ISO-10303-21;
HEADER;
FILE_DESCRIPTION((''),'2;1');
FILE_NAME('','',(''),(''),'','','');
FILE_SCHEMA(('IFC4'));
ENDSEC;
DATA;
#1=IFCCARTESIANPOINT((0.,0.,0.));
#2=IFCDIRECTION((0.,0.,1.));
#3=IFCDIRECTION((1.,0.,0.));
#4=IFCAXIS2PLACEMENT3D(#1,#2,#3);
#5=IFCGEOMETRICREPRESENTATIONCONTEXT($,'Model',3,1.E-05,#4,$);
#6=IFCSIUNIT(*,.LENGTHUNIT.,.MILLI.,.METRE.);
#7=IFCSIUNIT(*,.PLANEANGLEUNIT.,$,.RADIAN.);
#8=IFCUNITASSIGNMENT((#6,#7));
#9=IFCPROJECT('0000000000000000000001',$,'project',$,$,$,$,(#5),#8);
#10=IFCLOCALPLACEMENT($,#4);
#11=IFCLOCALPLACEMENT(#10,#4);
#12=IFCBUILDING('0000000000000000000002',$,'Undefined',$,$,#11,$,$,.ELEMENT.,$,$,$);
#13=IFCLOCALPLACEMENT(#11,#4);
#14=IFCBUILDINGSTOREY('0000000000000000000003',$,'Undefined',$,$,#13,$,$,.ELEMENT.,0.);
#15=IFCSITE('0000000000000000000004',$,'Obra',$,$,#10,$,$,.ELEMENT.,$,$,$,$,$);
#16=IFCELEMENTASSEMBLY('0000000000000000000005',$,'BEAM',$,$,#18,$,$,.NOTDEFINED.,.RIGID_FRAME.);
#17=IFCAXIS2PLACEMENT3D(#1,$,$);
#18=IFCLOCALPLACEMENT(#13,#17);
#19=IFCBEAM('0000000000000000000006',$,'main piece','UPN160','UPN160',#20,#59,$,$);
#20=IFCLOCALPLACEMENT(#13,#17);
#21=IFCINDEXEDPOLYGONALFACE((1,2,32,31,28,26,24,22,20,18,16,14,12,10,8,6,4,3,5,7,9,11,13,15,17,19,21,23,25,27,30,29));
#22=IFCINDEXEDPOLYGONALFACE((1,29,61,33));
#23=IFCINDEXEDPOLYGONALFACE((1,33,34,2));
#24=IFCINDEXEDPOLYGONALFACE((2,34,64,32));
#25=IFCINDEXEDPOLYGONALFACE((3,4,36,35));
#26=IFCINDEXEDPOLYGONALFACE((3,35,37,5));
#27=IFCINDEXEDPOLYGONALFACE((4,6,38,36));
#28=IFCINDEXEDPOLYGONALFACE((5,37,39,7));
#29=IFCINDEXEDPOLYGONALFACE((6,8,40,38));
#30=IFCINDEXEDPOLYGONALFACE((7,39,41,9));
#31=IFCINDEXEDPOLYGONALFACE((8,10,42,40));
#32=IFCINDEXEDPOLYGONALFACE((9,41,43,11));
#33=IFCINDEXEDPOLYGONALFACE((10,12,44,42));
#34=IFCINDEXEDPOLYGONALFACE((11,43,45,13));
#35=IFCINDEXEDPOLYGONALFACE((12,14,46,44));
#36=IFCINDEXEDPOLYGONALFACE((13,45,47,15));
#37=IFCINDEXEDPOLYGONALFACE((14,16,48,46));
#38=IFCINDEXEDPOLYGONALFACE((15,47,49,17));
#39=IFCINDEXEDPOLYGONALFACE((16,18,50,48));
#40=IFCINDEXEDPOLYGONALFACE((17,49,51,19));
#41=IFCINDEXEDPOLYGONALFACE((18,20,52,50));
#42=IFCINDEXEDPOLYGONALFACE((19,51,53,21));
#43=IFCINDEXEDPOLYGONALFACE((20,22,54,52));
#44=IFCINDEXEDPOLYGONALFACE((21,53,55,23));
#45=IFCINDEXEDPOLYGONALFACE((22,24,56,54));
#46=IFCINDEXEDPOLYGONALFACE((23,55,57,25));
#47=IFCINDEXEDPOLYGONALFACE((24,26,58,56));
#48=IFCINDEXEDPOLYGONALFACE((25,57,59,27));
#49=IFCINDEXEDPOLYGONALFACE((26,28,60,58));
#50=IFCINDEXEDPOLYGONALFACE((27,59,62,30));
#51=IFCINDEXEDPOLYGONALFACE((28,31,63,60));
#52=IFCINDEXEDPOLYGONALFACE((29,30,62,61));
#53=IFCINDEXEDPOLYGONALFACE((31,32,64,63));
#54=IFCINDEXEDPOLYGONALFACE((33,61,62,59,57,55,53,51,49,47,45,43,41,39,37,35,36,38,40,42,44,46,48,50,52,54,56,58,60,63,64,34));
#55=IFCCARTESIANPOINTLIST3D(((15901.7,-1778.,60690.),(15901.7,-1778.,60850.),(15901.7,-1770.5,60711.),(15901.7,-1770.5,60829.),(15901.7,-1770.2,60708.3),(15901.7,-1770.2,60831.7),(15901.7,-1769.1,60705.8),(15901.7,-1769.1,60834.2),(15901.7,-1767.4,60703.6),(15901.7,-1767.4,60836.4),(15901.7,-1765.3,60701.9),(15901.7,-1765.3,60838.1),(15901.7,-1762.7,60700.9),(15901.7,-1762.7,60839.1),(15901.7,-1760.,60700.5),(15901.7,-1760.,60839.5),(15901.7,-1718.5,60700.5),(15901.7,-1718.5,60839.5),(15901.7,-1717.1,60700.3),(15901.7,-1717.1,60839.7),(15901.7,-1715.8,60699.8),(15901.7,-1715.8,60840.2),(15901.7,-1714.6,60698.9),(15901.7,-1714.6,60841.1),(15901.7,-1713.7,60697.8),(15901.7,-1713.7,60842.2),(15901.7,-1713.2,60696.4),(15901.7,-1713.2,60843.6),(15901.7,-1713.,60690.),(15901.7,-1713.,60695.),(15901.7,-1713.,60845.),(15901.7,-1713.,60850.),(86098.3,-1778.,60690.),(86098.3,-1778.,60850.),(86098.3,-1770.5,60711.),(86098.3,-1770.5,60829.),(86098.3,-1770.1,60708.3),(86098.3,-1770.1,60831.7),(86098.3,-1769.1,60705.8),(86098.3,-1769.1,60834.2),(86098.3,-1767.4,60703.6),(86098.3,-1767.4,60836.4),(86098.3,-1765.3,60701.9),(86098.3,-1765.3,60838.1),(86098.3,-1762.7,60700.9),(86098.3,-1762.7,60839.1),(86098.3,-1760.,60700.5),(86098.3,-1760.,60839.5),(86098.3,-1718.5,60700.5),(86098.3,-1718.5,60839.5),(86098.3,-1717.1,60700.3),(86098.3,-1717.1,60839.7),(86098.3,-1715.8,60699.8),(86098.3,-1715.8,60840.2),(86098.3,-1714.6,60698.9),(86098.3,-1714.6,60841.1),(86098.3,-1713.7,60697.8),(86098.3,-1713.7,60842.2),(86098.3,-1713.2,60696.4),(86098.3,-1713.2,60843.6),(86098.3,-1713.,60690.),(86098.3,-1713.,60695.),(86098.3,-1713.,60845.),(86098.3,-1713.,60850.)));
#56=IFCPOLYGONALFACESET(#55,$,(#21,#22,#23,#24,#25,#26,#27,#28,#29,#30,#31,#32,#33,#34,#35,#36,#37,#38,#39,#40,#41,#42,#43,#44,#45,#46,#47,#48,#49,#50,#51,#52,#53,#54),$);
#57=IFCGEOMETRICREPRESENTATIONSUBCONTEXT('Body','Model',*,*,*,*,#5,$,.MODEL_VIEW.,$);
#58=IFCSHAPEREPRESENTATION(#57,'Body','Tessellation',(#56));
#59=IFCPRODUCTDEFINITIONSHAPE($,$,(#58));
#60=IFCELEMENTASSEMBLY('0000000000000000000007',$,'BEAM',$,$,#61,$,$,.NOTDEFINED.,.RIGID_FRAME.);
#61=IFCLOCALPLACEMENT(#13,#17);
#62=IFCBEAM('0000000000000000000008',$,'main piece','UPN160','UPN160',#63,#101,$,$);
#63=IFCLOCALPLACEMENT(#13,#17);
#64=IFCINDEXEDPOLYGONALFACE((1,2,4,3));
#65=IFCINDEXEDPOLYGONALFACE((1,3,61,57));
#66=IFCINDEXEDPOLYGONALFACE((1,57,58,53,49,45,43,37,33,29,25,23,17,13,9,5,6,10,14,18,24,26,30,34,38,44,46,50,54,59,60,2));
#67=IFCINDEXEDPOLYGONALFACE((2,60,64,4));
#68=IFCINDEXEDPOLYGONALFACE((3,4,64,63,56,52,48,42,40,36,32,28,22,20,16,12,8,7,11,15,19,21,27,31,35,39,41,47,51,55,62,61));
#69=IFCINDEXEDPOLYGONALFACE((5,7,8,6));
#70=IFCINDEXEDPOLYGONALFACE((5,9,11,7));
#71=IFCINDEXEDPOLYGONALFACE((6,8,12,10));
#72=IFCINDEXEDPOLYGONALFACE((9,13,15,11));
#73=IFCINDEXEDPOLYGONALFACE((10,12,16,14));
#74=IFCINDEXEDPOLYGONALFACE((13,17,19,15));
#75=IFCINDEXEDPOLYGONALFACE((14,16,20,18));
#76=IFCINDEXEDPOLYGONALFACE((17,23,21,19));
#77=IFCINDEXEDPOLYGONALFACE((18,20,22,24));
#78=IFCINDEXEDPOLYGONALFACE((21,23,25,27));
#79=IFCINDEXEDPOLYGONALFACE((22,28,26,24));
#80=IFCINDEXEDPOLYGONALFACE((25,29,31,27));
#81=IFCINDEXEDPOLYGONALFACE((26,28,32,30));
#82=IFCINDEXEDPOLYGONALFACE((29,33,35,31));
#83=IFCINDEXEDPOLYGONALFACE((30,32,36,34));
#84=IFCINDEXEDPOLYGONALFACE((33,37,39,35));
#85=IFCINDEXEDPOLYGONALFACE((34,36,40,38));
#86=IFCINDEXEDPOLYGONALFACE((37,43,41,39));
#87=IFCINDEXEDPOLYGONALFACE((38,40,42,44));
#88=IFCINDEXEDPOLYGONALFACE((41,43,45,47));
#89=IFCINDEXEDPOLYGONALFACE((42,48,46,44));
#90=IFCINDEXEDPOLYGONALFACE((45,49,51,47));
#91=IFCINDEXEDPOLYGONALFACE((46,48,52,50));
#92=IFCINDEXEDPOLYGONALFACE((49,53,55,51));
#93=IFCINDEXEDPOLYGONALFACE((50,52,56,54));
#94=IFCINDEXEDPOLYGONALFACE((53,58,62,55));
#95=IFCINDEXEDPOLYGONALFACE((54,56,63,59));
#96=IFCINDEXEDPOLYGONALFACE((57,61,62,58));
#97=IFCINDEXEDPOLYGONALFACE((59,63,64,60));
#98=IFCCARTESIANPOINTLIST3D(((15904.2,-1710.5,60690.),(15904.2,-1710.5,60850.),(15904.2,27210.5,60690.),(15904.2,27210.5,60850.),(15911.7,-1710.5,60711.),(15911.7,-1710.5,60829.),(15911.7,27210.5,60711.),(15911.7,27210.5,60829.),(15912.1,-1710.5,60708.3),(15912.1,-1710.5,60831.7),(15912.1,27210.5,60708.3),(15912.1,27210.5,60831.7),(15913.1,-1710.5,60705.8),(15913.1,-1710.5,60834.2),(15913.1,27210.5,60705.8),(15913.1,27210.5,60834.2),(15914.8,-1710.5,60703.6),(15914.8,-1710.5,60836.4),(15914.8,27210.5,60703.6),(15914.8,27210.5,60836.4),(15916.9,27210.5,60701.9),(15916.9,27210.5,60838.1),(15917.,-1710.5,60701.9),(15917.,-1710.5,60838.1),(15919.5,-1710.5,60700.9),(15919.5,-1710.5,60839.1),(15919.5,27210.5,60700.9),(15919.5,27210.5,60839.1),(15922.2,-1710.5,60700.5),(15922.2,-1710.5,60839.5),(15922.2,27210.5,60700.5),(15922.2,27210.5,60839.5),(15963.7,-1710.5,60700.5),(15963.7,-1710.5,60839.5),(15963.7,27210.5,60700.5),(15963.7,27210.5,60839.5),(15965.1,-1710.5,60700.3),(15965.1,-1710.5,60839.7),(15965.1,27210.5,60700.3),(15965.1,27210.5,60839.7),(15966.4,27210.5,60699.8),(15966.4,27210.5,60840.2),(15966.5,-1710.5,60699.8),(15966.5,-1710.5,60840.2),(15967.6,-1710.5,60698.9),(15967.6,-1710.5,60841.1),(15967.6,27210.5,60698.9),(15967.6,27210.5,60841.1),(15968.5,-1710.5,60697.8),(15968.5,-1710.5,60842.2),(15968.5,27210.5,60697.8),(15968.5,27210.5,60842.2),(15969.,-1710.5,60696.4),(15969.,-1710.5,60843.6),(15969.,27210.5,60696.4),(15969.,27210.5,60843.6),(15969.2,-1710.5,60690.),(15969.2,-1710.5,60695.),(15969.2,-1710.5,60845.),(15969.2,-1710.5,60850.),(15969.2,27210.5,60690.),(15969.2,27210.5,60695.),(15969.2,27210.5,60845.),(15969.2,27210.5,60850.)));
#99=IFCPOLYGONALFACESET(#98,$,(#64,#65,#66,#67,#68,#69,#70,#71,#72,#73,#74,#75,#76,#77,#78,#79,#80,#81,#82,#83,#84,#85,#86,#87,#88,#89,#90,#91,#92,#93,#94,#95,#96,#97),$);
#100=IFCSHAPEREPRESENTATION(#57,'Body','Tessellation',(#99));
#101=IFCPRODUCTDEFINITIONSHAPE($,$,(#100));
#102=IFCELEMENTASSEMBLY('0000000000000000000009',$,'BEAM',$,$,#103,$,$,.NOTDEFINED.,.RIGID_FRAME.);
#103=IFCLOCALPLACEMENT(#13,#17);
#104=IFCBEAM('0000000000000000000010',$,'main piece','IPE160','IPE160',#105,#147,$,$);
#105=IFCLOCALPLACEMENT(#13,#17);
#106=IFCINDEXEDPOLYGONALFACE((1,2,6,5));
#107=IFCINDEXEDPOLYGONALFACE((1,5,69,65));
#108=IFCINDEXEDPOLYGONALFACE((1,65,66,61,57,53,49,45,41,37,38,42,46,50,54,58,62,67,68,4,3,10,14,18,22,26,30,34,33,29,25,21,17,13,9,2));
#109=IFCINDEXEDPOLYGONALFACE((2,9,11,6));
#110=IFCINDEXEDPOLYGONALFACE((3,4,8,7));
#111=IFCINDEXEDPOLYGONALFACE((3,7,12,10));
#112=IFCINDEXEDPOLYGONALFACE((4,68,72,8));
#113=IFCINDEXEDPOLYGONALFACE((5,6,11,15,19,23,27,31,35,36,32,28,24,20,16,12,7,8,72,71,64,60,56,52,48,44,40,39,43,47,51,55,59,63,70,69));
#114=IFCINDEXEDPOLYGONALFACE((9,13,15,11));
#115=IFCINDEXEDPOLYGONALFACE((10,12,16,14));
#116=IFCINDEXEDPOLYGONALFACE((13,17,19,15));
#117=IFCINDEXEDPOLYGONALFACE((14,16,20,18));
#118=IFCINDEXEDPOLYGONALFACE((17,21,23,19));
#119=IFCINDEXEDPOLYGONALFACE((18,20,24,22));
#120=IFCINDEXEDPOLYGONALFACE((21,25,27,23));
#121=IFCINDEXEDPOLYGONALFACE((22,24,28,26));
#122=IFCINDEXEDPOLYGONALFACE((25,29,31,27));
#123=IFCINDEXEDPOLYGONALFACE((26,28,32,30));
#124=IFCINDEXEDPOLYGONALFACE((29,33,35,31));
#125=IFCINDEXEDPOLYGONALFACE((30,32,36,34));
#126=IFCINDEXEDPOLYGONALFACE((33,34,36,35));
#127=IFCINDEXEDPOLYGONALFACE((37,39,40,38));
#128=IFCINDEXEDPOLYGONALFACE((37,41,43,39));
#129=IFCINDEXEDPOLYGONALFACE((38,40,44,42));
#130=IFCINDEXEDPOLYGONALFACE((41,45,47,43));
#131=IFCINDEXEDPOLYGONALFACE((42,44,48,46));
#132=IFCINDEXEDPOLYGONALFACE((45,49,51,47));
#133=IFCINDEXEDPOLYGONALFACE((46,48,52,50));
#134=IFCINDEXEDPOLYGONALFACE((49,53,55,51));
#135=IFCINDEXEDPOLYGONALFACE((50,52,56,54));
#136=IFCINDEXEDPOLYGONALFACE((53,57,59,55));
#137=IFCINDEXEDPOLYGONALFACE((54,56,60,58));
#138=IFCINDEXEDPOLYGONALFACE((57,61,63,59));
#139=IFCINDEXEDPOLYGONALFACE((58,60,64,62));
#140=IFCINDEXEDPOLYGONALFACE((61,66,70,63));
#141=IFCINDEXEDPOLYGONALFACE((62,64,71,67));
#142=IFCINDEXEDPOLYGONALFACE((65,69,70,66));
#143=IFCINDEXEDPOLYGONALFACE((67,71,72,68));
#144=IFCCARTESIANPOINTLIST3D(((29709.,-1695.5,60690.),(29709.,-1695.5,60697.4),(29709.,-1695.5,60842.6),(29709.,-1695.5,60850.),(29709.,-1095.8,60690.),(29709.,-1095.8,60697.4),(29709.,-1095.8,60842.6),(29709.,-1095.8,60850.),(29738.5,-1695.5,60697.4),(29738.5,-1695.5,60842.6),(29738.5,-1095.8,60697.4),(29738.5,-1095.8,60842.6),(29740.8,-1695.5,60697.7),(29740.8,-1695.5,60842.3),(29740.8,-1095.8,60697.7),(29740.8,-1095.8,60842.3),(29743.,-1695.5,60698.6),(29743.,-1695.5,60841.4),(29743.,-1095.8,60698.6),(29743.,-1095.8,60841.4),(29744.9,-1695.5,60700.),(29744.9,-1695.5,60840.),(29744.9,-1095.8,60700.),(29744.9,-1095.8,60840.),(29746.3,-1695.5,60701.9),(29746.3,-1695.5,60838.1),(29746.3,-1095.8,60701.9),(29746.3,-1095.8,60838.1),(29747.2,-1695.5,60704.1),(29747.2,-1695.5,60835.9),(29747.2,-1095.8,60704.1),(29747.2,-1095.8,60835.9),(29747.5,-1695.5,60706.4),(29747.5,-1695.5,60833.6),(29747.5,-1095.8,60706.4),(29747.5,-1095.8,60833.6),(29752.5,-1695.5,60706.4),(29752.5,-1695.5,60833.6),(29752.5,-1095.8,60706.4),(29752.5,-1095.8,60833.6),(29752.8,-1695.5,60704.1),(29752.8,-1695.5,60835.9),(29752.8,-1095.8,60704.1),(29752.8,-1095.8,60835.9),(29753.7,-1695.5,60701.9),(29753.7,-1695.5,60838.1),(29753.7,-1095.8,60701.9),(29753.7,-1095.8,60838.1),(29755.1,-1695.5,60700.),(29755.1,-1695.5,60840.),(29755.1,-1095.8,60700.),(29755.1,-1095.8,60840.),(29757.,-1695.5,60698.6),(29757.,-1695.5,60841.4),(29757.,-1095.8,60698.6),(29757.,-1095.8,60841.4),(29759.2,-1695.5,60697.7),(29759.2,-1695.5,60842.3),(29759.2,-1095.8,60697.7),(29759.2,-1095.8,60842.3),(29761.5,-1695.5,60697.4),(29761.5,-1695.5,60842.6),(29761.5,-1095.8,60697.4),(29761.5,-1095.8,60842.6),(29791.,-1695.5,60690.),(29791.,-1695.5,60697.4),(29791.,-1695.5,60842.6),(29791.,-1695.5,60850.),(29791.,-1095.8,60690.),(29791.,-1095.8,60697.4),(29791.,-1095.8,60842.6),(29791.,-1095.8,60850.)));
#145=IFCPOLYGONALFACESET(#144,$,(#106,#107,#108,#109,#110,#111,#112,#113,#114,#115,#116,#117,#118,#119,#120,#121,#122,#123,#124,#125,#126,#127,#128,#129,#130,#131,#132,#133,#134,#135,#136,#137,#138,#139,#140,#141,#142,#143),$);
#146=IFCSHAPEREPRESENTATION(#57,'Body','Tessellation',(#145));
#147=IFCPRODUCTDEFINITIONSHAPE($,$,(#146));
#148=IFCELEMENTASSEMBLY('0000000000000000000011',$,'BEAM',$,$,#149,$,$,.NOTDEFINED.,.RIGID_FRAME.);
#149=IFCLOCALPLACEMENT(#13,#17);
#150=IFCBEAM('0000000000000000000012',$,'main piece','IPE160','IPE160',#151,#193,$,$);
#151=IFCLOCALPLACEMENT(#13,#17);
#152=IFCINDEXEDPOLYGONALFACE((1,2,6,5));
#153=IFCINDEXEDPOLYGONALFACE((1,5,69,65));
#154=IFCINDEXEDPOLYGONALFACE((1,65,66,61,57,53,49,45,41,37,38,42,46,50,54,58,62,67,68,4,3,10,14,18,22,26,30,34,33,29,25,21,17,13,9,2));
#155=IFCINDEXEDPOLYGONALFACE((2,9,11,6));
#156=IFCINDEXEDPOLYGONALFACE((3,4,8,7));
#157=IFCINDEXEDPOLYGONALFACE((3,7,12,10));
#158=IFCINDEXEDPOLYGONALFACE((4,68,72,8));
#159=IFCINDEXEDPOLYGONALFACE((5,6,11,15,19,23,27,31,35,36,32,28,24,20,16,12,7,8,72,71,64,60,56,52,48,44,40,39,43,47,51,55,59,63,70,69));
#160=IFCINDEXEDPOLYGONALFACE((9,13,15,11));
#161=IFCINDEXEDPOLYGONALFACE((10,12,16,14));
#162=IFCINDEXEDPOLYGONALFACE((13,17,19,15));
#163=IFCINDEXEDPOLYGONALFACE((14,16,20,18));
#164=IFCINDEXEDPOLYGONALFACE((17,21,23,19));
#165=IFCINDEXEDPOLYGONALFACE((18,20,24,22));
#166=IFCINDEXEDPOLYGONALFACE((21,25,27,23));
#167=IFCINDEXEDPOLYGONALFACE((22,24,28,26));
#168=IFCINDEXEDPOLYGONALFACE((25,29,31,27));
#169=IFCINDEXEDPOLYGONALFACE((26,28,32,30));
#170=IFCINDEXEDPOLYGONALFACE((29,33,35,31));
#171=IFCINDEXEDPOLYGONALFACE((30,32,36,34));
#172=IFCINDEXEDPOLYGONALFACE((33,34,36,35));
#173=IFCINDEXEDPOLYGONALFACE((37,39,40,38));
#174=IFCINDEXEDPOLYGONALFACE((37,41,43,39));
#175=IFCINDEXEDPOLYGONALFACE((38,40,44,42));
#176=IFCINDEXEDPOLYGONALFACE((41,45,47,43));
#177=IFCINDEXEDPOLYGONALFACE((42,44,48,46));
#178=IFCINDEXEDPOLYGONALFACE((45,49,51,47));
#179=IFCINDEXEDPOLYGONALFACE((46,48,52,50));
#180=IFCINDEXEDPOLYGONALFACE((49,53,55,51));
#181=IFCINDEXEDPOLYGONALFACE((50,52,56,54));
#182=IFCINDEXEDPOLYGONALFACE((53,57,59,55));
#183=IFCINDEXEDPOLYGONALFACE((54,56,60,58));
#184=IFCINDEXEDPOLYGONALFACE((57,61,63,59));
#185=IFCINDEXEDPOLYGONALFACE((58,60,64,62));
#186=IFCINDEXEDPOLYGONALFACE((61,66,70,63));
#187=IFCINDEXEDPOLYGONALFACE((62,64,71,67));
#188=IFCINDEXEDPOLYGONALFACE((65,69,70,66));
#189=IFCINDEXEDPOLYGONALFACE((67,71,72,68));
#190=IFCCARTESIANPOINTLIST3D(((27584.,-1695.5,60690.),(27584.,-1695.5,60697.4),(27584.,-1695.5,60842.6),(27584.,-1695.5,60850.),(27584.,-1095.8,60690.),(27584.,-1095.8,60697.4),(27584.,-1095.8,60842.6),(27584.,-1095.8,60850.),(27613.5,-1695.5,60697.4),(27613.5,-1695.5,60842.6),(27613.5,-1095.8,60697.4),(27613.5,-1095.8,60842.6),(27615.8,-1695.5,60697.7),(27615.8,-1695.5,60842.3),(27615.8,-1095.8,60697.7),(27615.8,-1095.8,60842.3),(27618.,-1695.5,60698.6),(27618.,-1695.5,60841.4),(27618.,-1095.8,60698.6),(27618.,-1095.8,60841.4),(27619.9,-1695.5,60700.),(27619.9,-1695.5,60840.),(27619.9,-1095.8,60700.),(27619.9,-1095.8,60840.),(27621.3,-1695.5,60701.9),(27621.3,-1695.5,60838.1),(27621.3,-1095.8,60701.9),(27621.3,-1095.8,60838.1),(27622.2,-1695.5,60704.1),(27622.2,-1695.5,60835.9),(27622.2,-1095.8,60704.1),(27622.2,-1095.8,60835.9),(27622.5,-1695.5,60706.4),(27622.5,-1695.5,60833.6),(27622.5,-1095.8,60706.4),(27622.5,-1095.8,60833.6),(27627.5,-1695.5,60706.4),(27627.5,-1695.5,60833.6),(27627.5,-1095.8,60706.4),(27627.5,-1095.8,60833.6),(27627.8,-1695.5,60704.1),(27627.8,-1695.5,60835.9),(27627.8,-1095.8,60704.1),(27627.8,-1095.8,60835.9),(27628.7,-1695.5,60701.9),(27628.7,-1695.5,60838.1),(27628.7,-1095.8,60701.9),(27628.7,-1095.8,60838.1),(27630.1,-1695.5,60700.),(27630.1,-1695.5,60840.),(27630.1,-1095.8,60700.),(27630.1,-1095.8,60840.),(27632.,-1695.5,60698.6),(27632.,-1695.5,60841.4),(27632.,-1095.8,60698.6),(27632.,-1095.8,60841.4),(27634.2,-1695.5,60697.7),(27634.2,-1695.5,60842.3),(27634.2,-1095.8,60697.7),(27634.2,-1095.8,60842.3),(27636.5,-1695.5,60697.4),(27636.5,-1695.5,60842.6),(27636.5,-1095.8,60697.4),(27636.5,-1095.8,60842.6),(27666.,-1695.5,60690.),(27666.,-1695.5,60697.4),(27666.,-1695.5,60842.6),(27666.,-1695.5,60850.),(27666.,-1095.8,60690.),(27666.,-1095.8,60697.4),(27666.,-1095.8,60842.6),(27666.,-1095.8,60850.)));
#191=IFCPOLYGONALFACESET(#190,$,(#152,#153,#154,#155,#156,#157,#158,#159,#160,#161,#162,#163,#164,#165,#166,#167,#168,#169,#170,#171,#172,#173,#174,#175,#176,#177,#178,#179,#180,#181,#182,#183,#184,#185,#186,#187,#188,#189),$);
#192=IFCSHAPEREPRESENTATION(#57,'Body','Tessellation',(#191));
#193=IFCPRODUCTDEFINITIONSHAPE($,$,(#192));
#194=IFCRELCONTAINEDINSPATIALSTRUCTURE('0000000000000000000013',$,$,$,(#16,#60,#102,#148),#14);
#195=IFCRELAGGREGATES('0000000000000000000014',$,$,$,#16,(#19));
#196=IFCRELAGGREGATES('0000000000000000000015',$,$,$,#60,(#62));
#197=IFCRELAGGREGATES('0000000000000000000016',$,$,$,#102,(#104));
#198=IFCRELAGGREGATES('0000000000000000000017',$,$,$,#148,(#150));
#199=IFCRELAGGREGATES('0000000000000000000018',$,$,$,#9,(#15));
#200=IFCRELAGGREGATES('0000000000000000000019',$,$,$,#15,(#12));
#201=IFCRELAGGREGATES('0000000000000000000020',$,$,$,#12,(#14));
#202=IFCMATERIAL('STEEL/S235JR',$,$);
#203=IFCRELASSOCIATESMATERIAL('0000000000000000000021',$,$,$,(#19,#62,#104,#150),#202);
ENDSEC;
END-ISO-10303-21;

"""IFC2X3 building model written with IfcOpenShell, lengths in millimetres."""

from ifc_helpers import new_model, si_unit, frame, origin_with_axes, origin_2d_with_axis, place, context, subcontext, project, spatial, i_section, u_section, extrude, material, element, aggregate, save


model = new_model("IFC2X3")

# Units and contexts
model_context = context("Model", 3, precision=1e-05, world=origin_with_axes())
body_context = subcontext(model_context, "Body", "Model", "MODEL_VIEW")
ifc_project = project(units=[si_unit("LENGTHUNIT", "METRE", prefix="MILLI"), si_unit("PLANEANGLEUNIT", "RADIAN")], contexts=[model_context])

# Site, building, storey
site_placement = place(None, origin_with_axes())
site = spatial("IfcSite", under=ifc_project, at=site_placement, Name="Obra", CompositionType="ELEMENT")
building_placement = place(site_placement, origin_with_axes())
building = spatial("IfcBuilding", under=site, at=building_placement, Name="Undefined", CompositionType="ELEMENT")
storey_placement = place(building_placement, origin_with_axes())
storey = spatial("IfcBuildingStorey", under=building, at=storey_placement, Name="Undefined", CompositionType="ELEMENT", Elevation=0.0)

# Element assemblies, beams
assembly_1_placement = place(storey_placement, origin_with_axes())
assembly_1 = element("IfcElementAssembly", 1, at=assembly_1_placement, inside=storey, Name="BEAM", AssemblyPlace="NOTDEFINED", PredefinedType="RIGID_FRAME")
ifc_material_1 = material(Name="STEEL/S235JR")
beam_1_placement = place(assembly_1_placement, frame((15901.7, -1745.5, 60770.0), z_axis=(0.0, 0.0, -1.0), x_axis=(1.0, 0.0, 0.0)))
beam_1 = element("IfcBeam", 2, at=beam_1_placement, material=ifc_material_1, Name="main piece", Description="UPN160", ObjectType="UPN160", context=body_context, shape_type="SweptSolid", body=[
    extrude(u_section(Depth=160.0, FlangeWidth=65.0, WebThickness=7.5, FlangeThickness=10.5, FilletRadius=10.5, EdgeRadius=5.5, at=origin_2d_with_axis()), frame((70196.6, 0.0, 0.0), z_axis=(-1.0, 0.0, 0.0), x_axis=(0.0, -1.0, 0.0)), (0.0, 0.0, 1.0), 70196.6),
])
aggregate(assembly_1, [beam_1])
assembly_2_placement = place(storey_placement, origin_with_axes())
assembly_2 = element("IfcElementAssembly", 3, at=assembly_2_placement, inside=storey, Name="BEAM", AssemblyPlace="NOTDEFINED", PredefinedType="RIGID_FRAME")
beam_2_placement = place(assembly_2_placement, frame((15936.7, 27210.5, 60770.0), z_axis=(0.0, 0.0, -1.0), x_axis=(0.0, -1.0, 0.0)))
beam_2 = element("IfcBeam", 4, at=beam_2_placement, material=ifc_material_1, Name="main piece", Description="UPN160", ObjectType="UPN160", context=body_context, shape_type="SweptSolid", body=[
    extrude(u_section(Depth=160.0, FlangeWidth=65.0, WebThickness=7.5, FlangeThickness=10.5, FilletRadius=10.5, EdgeRadius=5.5, at=origin_2d_with_axis()), frame((28921.0, 0.0, 0.0), z_axis=(-1.0, 0.0, 0.0), x_axis=(0.0, -1.0, 0.0)), (0.0, 0.0, 1.0), 28921.0),
])
aggregate(assembly_2, [beam_2])
assembly_3_placement = place(storey_placement, origin_with_axes())
assembly_3 = element("IfcElementAssembly", 5, at=assembly_3_placement, inside=storey, Name="BEAM", AssemblyPlace="NOTDEFINED", PredefinedType="RIGID_FRAME")
beam_3_placement = place(assembly_3_placement, frame((29750.0, -1095.8, 60770.0), z_axis=(0.0, 0.0, 1.0), x_axis=(0.0, -1.0, 0.0)))
beam_3 = element("IfcBeam", 6, at=beam_3_placement, material=ifc_material_1, Name="main piece", Description="IPE160", ObjectType="IPE160", context=body_context, shape_type="SweptSolid", body=[
    extrude(i_section(OverallWidth=82.0, OverallDepth=160.0, WebThickness=5.0, FlangeThickness=7.4, FilletRadius=9.0, at=origin_2d_with_axis()), frame((599.7, 0.0, 0.0), z_axis=(-1.0, 0.0, 0.0), x_axis=(0.0, -1.0, 0.0)), (0.0, 0.0, 1.0), 599.7),
])
aggregate(assembly_3, [beam_3])
assembly_4_placement = place(storey_placement, origin_with_axes())
assembly_4 = element("IfcElementAssembly", 7, at=assembly_4_placement, inside=storey, Name="BEAM", AssemblyPlace="NOTDEFINED", PredefinedType="RIGID_FRAME")
beam_4_placement = place(assembly_4_placement, frame((27625.0, -1695.5, 60770.0), z_axis=(0.0, 0.0, 1.0), x_axis=(0.0, 1.0, 0.0)))
beam_4 = element("IfcBeam", 8, at=beam_4_placement, material=ifc_material_1, Name="main piece", Description="IPE160", ObjectType="IPE160", context=body_context, shape_type="SweptSolid", body=[
    extrude(i_section(OverallWidth=82.0, OverallDepth=160.0, WebThickness=5.0, FlangeThickness=7.4, FilletRadius=9.0, at=origin_2d_with_axis()), frame((599.7, 0.0, 0.0), z_axis=(-1.0, 0.0, 0.0), x_axis=(0.0, -1.0, 0.0)), (0.0, 0.0, 1.0), 599.7),
])
aggregate(assembly_4, [beam_4])

save(model, "model.ifc")
